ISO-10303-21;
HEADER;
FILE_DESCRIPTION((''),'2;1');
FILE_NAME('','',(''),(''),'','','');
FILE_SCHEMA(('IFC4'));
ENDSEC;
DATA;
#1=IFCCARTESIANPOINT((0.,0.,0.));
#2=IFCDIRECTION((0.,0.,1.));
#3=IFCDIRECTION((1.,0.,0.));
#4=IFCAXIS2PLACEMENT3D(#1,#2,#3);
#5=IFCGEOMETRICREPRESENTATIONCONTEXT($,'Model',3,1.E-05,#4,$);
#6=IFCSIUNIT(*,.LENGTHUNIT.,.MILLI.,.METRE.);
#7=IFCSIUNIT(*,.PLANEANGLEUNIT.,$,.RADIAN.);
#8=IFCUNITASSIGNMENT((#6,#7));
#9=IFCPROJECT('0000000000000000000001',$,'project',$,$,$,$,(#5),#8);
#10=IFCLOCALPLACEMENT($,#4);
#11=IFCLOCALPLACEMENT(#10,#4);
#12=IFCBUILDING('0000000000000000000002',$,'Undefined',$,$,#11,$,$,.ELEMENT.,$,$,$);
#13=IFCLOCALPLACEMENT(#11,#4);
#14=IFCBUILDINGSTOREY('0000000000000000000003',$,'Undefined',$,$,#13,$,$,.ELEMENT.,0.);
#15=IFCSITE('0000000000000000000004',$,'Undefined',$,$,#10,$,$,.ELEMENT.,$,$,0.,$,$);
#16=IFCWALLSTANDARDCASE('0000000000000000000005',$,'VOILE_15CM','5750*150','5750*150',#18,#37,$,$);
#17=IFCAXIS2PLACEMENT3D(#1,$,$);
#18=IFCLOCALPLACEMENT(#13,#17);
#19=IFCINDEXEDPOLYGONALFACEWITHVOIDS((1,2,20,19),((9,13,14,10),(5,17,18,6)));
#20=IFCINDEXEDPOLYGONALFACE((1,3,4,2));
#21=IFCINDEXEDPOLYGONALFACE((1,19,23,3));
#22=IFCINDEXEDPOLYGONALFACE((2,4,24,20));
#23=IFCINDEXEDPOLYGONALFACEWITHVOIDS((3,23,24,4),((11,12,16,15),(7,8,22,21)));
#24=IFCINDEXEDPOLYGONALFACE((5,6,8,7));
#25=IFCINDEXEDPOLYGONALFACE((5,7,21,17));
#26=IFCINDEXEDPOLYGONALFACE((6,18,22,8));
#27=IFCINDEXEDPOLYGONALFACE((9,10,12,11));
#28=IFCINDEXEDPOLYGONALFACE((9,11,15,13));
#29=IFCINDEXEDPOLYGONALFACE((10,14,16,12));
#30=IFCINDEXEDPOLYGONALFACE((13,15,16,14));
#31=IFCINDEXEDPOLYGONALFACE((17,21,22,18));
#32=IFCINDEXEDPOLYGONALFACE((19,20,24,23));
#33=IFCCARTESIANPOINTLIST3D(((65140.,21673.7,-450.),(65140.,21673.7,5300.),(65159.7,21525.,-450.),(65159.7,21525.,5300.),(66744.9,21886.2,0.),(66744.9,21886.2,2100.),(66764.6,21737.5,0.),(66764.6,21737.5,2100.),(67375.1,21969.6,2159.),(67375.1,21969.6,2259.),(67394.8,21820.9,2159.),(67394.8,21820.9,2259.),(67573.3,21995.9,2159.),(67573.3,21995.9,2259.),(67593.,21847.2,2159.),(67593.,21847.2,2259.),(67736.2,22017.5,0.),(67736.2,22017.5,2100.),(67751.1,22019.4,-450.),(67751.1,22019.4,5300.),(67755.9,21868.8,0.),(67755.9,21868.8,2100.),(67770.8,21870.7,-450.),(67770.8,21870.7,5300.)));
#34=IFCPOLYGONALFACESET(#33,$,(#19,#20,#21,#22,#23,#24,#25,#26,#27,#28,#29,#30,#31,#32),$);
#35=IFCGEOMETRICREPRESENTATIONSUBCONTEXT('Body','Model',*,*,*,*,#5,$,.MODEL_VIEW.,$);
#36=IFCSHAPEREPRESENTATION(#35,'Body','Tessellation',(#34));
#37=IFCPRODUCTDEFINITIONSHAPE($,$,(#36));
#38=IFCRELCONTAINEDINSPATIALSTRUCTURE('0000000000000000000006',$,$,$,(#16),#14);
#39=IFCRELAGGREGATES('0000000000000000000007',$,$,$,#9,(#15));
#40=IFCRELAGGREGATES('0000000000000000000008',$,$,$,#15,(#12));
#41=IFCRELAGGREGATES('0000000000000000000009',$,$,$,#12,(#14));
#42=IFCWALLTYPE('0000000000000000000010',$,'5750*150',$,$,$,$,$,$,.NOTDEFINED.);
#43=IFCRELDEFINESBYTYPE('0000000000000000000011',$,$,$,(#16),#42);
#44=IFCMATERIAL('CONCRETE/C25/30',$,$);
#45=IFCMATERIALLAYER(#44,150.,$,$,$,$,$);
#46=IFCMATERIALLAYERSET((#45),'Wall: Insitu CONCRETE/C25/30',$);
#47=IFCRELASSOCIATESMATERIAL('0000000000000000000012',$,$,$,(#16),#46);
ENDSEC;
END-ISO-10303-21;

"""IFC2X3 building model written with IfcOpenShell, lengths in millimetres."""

from ifc_helpers import new_model, si_unit, frame, frame_2d, origin_with_axes, origin_2d_with_axis, place, context, subcontext, project, spatial, polyline, rectangle, outline, extrude, boolean, material, layer, layer_set, layer_usage, type_object, element, save


model = new_model("IFC2X3")

# Units and contexts
model_context = context("Model", 3, precision=1e-05, world=origin_with_axes())
body_context = subcontext(model_context, "Body", "Model", "MODEL_VIEW")
ifc_project = project(units=[si_unit("LENGTHUNIT", "METRE", prefix="MILLI"), si_unit("PLANEANGLEUNIT", "RADIAN")], contexts=[model_context])

# Site, building, storey
site_placement = place(None, origin_with_axes())
site = spatial("IfcSite", under=ifc_project, at=site_placement, Name="Undefined", CompositionType="ELEMENT", RefElevation=0.0)
building_placement = place(site_placement, origin_with_axes())
building = spatial("IfcBuilding", under=site, at=building_placement, Name="Undefined", CompositionType="ELEMENT")
storey_placement = place(building_placement, origin_with_axes())
storey = spatial("IfcBuildingStorey", under=building, at=storey_placement, Name="Undefined", CompositionType="ELEMENT", Elevation=0.0)

# Shared definitions
ifc_material_1 = material(Name="CONCRETE/C25/30")

# Wall
wall_type_1 = type_object("IfcWallType", Name="5750*150", PredefinedType="NOTDEFINED")
ifc_layer_1 = layer(ifc_material_1, 150.0)
ifc_layer_set_1 = layer_set([ifc_layer_1], Name="Wall: Insitu CONCRETE/C25/30")
ifc_layer_usage_1 = layer_usage(ifc_layer_set_1, "AXIS2", "POSITIVE", -75.0)
wall_1_placement = place(storey_placement, frame((67746.1, 21943.1, -450.0), z_axis=(0.0, 0.0, 1.0), x_axis=(-0.991345, -0.131283, 0.0)))
element("IfcWallStandardCase", 1, at=wall_1_placement, inside=storey, type_object=wall_type_1, material=ifc_layer_usage_1, Name="VOILE_15CM", Description="5750*150", ObjectType="5750*150", context=body_context, shape_type="CSG", body=[
    boolean("DIFFERENCE", boolean("DIFFERENCE", extrude(rectangle(XDim=2633.9, YDim=150.0, at=frame_2d((0.0, 1301.9), x_axis=(0.0, -1.0))), frame((0.0, 0.0, 0.0), z_axis=(0.0, 0.0, 1.0), x_axis=(0.0, -1.0, 0.0)), (0.0, 0.0, 1.0), 5750.0), extrude(rectangle(XDim=200.0, YDim=100.0, at=origin_2d_with_axis()), frame((264.3, -85.0, 2659.0), z_axis=(0.0, 1.0, 0.0), x_axis=(-1.0, 0.0, 0.0)), (0.0, 0.0, 1.0), 170.0)), extrude(outline(polyline([(0.0, 0.0), (2100.0, 0.0), (2100.0, 1000.0), (0.0, 1000.0), (0.0, 0.0)])), frame((0.0, 85.0, 2550.0), z_axis=(0.0, -1.0, 0.0), x_axis=(0.0, 0.0, -1.0)), (0.0, 0.0, 1.0), 170.0)),
])

save(model, "model.ifc")
